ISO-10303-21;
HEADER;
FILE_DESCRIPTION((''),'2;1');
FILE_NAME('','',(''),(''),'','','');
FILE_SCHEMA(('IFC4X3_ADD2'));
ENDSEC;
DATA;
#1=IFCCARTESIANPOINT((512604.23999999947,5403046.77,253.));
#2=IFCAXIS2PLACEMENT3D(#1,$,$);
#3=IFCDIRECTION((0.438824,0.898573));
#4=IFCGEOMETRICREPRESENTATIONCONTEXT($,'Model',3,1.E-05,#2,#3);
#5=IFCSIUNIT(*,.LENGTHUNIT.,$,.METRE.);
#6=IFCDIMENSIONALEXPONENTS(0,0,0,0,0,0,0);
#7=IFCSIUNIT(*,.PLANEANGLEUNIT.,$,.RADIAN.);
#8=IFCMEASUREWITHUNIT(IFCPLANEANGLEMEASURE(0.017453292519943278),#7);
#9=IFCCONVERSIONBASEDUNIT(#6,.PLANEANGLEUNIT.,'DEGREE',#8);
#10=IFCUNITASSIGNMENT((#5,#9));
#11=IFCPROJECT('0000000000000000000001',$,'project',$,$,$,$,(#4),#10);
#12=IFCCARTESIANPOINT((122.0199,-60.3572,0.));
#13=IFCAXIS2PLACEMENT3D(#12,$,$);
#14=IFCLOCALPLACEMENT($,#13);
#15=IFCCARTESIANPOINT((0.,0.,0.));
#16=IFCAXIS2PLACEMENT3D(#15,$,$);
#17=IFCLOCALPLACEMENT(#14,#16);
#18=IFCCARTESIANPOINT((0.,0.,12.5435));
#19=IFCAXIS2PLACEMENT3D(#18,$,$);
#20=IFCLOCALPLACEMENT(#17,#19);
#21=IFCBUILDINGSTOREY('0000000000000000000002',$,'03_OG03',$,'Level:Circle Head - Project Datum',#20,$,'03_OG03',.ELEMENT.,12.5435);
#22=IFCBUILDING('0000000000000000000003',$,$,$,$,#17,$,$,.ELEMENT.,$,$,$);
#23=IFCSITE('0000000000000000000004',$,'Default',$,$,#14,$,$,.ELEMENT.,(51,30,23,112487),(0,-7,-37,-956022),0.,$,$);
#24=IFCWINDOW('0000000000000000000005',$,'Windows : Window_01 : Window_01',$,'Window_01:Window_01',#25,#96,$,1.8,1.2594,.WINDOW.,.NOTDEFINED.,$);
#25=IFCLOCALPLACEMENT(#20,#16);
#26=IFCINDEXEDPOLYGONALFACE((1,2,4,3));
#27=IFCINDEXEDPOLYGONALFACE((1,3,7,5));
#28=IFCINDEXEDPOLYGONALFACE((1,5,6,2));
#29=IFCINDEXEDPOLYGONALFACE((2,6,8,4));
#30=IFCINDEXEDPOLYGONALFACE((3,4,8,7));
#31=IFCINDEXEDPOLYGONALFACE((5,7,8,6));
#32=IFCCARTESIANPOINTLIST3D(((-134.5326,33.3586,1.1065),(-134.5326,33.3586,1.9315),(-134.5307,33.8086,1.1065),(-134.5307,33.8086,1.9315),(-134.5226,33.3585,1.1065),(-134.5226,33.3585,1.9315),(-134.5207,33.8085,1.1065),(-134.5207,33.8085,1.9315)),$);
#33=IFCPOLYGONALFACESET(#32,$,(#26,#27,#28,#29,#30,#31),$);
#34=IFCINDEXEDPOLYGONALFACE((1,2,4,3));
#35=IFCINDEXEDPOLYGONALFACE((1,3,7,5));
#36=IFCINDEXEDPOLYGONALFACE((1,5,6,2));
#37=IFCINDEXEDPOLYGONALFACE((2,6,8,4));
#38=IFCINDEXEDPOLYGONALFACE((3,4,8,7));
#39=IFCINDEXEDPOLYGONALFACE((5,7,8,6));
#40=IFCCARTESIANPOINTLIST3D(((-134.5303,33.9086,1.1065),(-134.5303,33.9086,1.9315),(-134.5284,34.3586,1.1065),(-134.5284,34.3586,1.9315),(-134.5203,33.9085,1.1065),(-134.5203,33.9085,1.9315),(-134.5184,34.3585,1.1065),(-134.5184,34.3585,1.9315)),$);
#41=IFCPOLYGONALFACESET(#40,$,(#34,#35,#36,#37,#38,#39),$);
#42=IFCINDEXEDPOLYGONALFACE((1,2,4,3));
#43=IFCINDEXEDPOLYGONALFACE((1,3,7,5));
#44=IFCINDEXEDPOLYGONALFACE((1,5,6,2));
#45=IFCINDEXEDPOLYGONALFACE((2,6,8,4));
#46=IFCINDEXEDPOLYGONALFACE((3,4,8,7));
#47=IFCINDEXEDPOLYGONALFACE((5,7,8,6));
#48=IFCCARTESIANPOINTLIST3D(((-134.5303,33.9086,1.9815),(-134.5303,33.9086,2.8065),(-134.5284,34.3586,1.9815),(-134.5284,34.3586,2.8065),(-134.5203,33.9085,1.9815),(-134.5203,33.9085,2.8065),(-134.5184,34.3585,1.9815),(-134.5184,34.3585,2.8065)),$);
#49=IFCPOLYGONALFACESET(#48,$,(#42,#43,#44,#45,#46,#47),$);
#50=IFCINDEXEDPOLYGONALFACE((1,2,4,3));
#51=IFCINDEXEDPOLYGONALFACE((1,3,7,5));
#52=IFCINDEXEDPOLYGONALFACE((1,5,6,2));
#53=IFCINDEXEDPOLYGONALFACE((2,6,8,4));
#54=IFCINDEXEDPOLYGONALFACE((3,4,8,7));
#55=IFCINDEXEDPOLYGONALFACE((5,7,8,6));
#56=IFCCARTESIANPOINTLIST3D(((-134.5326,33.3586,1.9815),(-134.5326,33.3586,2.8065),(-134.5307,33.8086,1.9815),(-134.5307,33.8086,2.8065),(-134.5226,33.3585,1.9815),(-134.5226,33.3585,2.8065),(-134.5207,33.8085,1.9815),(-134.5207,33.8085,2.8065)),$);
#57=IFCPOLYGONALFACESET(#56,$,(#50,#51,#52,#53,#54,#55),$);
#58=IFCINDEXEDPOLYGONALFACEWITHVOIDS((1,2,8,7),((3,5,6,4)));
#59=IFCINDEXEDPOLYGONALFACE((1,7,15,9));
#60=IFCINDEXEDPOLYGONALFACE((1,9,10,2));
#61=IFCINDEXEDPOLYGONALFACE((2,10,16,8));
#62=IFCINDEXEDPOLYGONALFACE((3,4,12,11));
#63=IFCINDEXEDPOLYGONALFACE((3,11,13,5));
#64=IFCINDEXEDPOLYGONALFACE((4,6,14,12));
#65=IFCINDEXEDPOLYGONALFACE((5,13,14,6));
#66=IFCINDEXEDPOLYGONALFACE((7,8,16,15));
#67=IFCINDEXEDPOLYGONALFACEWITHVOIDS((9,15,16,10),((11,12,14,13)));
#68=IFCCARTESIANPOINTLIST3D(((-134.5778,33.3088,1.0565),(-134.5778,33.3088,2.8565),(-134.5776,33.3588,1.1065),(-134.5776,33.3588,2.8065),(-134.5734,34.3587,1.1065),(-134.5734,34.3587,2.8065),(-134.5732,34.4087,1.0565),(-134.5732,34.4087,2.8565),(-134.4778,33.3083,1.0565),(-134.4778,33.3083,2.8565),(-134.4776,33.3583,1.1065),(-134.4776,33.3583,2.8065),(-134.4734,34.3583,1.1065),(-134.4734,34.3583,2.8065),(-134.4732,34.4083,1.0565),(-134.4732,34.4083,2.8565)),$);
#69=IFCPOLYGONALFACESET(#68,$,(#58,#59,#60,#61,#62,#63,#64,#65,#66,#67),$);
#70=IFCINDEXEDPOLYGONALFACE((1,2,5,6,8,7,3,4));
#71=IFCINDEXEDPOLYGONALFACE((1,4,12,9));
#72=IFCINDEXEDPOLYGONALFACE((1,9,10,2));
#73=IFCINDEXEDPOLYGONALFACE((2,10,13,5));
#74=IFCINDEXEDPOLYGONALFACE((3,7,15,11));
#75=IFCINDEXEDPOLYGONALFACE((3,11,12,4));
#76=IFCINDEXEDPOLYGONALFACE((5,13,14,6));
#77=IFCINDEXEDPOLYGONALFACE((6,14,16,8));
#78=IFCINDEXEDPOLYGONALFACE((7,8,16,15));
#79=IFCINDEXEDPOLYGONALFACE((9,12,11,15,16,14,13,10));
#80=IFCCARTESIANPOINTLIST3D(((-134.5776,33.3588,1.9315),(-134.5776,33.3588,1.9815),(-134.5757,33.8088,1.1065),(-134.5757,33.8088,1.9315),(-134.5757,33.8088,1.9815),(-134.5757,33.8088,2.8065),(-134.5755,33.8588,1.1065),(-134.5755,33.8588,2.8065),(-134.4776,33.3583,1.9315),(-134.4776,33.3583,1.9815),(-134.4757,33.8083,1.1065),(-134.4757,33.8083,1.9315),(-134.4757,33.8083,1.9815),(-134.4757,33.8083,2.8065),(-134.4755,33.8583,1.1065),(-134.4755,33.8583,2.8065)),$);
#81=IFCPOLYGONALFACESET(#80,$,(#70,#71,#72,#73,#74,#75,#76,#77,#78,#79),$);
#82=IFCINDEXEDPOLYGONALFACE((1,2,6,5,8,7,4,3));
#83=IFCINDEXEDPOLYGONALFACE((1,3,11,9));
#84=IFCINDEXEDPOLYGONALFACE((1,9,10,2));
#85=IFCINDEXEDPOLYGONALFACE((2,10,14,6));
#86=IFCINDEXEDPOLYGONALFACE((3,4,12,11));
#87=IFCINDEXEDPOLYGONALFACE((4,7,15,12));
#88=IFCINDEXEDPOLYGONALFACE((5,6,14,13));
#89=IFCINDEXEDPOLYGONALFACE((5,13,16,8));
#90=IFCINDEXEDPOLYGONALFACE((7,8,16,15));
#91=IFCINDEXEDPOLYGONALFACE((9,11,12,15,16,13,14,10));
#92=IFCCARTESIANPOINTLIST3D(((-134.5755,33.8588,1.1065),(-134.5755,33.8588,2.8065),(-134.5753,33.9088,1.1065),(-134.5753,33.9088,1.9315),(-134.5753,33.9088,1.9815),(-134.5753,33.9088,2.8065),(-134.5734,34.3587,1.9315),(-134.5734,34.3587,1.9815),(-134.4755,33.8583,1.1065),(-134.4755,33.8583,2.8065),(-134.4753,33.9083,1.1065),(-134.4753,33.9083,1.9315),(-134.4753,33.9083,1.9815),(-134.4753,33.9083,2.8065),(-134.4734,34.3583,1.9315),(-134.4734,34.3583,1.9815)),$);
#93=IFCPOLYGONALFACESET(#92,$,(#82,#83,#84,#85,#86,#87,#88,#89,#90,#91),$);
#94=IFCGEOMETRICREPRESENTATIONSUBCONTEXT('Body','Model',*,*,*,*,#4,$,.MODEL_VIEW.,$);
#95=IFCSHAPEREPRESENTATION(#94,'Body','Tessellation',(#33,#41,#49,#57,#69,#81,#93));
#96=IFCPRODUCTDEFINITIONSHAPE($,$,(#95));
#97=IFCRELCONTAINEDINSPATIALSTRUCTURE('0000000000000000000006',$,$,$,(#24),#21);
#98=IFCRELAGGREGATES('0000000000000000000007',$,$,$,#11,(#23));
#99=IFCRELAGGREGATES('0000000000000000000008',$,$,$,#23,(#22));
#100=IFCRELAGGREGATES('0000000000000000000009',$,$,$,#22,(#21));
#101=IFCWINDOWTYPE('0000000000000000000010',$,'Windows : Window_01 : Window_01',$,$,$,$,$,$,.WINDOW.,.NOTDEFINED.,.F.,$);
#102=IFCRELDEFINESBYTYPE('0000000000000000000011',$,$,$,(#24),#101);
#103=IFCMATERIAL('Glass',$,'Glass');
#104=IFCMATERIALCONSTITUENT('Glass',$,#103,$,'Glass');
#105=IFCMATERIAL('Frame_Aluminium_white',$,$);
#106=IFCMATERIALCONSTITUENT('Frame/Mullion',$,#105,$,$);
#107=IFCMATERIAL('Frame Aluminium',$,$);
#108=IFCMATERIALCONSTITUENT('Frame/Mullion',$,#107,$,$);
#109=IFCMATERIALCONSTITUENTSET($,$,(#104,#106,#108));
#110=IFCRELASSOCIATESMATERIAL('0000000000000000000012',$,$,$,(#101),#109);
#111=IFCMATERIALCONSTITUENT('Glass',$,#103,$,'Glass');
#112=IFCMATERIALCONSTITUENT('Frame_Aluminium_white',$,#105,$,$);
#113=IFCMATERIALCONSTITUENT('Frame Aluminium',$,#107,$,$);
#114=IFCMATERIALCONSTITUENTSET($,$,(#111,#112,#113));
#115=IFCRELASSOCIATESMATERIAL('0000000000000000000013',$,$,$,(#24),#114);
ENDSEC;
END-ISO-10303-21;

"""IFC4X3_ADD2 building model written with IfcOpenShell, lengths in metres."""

from ifc_helpers import new_model, entity, si_unit, converted_unit, direction, frame, frame_2d, origin, place, context, subcontext, project, spatial, polyline, rectangle, outline, extrude, source, transform, mapped, material, constituent, constituent_set, type_object, type_shapes, element, save


model = new_model("IFC4X3_ADD2")

# Units and contexts
model_context = context("Model", 3, precision=1e-05, world=frame((512604.23999999947, 5403046.77, 253.0)), true_north=direction((0.438824, 0.898573)))
body_context = subcontext(model_context, "Body", "Model", "MODEL_VIEW")
ifc_project = project(units=[si_unit("LENGTHUNIT", "METRE"), converted_unit("PLANEANGLEUNIT", "DEGREE", entity("IfcPlaneAngleMeasure", 0.017453292519943278), si_unit("PLANEANGLEUNIT", "RADIAN"), dimensions=[0, 0, 0, 0, 0, 0, 0])], contexts=[model_context])

# Site, building, storey
site_placement = place(None, frame((122.0199, -60.3572, 0.0)))
site = spatial("IfcSite", under=ifc_project, at=site_placement, Name="Default", CompositionType="ELEMENT", RefLatitude=(51, 30, 23, 112487), RefLongitude=(0, -7, -37, -956022), RefElevation=0.0)
building_placement = place(site_placement, origin())
building = spatial("IfcBuilding", under=site, at=building_placement, CompositionType="ELEMENT")
storey_placement = place(building_placement, frame((0.0, 0.0, 12.5435)))
storey = spatial("IfcBuildingStorey", under=building, at=storey_placement, Name="03_OG03", ObjectType="Level:Circle Head - Project Datum", LongName="03_OG03", CompositionType="ELEMENT", Elevation=12.5435)

# Window
ifc_material_1 = material(Name="Glass", Category="Glass")
ifc_material_2 = material(Name="Frame_Aluminium_white")
ifc_material_3 = material(Name="Frame Aluminium")
ifc_constituent_1 = constituent(ifc_material_1, Name="Glass", Category="Glass")
ifc_constituent_2 = constituent(ifc_material_2, Name="Frame_Aluminium_white")
ifc_constituent_3 = constituent(ifc_material_3, Name="Frame Aluminium")
ifc_constituent_set_1 = constituent_set(constituents=[ifc_constituent_1, ifc_constituent_2, ifc_constituent_3])
ifc_constituent_4 = constituent(ifc_material_1, Name="Glass", Category="Glass")
ifc_constituent_5 = constituent(ifc_material_2, Name="Frame/Mullion")
ifc_constituent_6 = constituent(ifc_material_3, Name="Frame/Mullion")
ifc_constituent_set_2 = constituent_set(constituents=[ifc_constituent_4, ifc_constituent_5, ifc_constituent_6])
window_type_1 = type_object("IfcWindowType", Name="Windows : Window_01 : Window_01", ParameterTakesPrecedence=False, PartitioningType="NOTDEFINED", PredefinedType="WINDOW", material=ifc_constituent_set_2)
shared_shape_1 = source(origin(), body_context, "Body", "SweptSolid", [
    extrude(rectangle(XDim=0.45, YDim=0.01, at=frame_2d((0.0, 0.0), x_axis=(1.0, 0.0))), frame((0.3639, -0.225, 0.05), z_axis=(0.0, 0.0, 1.0), x_axis=(-1.0, 0.0, 0.0)), (0.0, 0.0, 1.0), 0.825),
    extrude(rectangle(XDim=0.45, YDim=0.01, at=frame_2d((0.0, 0.0), x_axis=(1.0, 0.0))), frame((0.9139, -0.225, 0.05), z_axis=(0.0, 0.0, 1.0), x_axis=(-1.0, 0.0, 0.0)), (0.0, 0.0, 1.0), 0.825),
    extrude(rectangle(XDim=0.45, YDim=0.01, at=frame_2d((0.0, 0.0), x_axis=(1.0, 0.0))), frame((0.9139, -0.225, 0.925), z_axis=(0.0, 0.0, 1.0), x_axis=(-1.0, 0.0, 0.0)), (0.0, 0.0, 1.0), 0.825),
    extrude(rectangle(XDim=0.45, YDim=0.01, at=frame_2d((0.0, 0.0), x_axis=(1.0, 0.0))), frame((0.3639, -0.225, 0.925), z_axis=(0.0, 0.0, 1.0), x_axis=(-1.0, 0.0, 0.0)), (0.0, 0.0, 1.0), 0.825),
    extrude(outline(polyline([(-0.9, -0.55), (0.9, -0.55), (0.9, 0.55), (-0.9, 0.55), (-0.9, -0.55)]), holes=[polyline([(0.85, 0.5), (0.85, -0.5), (-0.85, -0.5), (-0.85, 0.5), (0.85, 0.5)])]), frame((0.6389, -0.275, 0.9), z_axis=(0.0, 1.0, 0.0), x_axis=(0.0, 0.0, 1.0)), (0.0, 0.0, 1.0), 0.1),
    extrude(outline(polyline([(0.025, 0.1), (0.85, 0.1), (0.85, 0.15), (-0.85, 0.15), (-0.85, 0.1), (-0.025, 0.1), (-0.025, -0.35), (0.025, -0.35), (0.025, 0.1)])), frame((0.4889, -0.275, 0.9), z_axis=(0.0, 1.0, 0.0), x_axis=(0.0, 0.0, 1.0)), (0.0, 0.0, 1.0), 0.1),
    extrude(outline(polyline([(-0.85, -0.1), (-0.85, -0.15), (0.85, -0.15), (0.85, -0.1), (0.025, -0.1), (0.025, 0.35), (-0.025, 0.35), (-0.025, -0.1), (-0.85, -0.1)])), frame((0.7889, -0.275, 0.9), z_axis=(0.0, -1.0, 0.0), x_axis=(0.0, 0.0, -1.0)), (0.0, 0.0, -1.0), 0.1),
])
type_shapes(window_type_1, [shared_shape_1])
window_1_placement = place(storey_placement, frame((-134.7532, 33.2206, 1.0565), z_axis=(0.0, 0.0, 1.0), x_axis=(0.004192, 0.999991, 0.0)))
element("IfcWindow", 1, at=window_1_placement, inside=storey, type_object=window_type_1, material=ifc_constituent_set_1, Name="Windows : Window_01 : Window_01", ObjectType="Window_01:Window_01", OverallHeight=1.8, OverallWidth=1.2594, PartitioningType="NOTDEFINED", PredefinedType="WINDOW", context=body_context, shape_type="MappedRepresentation", body=[
    mapped(shared_shape_1, transform((0.0, 0.0, 0.0), scale=1.0)),
])

save(model, "model.ifc")
